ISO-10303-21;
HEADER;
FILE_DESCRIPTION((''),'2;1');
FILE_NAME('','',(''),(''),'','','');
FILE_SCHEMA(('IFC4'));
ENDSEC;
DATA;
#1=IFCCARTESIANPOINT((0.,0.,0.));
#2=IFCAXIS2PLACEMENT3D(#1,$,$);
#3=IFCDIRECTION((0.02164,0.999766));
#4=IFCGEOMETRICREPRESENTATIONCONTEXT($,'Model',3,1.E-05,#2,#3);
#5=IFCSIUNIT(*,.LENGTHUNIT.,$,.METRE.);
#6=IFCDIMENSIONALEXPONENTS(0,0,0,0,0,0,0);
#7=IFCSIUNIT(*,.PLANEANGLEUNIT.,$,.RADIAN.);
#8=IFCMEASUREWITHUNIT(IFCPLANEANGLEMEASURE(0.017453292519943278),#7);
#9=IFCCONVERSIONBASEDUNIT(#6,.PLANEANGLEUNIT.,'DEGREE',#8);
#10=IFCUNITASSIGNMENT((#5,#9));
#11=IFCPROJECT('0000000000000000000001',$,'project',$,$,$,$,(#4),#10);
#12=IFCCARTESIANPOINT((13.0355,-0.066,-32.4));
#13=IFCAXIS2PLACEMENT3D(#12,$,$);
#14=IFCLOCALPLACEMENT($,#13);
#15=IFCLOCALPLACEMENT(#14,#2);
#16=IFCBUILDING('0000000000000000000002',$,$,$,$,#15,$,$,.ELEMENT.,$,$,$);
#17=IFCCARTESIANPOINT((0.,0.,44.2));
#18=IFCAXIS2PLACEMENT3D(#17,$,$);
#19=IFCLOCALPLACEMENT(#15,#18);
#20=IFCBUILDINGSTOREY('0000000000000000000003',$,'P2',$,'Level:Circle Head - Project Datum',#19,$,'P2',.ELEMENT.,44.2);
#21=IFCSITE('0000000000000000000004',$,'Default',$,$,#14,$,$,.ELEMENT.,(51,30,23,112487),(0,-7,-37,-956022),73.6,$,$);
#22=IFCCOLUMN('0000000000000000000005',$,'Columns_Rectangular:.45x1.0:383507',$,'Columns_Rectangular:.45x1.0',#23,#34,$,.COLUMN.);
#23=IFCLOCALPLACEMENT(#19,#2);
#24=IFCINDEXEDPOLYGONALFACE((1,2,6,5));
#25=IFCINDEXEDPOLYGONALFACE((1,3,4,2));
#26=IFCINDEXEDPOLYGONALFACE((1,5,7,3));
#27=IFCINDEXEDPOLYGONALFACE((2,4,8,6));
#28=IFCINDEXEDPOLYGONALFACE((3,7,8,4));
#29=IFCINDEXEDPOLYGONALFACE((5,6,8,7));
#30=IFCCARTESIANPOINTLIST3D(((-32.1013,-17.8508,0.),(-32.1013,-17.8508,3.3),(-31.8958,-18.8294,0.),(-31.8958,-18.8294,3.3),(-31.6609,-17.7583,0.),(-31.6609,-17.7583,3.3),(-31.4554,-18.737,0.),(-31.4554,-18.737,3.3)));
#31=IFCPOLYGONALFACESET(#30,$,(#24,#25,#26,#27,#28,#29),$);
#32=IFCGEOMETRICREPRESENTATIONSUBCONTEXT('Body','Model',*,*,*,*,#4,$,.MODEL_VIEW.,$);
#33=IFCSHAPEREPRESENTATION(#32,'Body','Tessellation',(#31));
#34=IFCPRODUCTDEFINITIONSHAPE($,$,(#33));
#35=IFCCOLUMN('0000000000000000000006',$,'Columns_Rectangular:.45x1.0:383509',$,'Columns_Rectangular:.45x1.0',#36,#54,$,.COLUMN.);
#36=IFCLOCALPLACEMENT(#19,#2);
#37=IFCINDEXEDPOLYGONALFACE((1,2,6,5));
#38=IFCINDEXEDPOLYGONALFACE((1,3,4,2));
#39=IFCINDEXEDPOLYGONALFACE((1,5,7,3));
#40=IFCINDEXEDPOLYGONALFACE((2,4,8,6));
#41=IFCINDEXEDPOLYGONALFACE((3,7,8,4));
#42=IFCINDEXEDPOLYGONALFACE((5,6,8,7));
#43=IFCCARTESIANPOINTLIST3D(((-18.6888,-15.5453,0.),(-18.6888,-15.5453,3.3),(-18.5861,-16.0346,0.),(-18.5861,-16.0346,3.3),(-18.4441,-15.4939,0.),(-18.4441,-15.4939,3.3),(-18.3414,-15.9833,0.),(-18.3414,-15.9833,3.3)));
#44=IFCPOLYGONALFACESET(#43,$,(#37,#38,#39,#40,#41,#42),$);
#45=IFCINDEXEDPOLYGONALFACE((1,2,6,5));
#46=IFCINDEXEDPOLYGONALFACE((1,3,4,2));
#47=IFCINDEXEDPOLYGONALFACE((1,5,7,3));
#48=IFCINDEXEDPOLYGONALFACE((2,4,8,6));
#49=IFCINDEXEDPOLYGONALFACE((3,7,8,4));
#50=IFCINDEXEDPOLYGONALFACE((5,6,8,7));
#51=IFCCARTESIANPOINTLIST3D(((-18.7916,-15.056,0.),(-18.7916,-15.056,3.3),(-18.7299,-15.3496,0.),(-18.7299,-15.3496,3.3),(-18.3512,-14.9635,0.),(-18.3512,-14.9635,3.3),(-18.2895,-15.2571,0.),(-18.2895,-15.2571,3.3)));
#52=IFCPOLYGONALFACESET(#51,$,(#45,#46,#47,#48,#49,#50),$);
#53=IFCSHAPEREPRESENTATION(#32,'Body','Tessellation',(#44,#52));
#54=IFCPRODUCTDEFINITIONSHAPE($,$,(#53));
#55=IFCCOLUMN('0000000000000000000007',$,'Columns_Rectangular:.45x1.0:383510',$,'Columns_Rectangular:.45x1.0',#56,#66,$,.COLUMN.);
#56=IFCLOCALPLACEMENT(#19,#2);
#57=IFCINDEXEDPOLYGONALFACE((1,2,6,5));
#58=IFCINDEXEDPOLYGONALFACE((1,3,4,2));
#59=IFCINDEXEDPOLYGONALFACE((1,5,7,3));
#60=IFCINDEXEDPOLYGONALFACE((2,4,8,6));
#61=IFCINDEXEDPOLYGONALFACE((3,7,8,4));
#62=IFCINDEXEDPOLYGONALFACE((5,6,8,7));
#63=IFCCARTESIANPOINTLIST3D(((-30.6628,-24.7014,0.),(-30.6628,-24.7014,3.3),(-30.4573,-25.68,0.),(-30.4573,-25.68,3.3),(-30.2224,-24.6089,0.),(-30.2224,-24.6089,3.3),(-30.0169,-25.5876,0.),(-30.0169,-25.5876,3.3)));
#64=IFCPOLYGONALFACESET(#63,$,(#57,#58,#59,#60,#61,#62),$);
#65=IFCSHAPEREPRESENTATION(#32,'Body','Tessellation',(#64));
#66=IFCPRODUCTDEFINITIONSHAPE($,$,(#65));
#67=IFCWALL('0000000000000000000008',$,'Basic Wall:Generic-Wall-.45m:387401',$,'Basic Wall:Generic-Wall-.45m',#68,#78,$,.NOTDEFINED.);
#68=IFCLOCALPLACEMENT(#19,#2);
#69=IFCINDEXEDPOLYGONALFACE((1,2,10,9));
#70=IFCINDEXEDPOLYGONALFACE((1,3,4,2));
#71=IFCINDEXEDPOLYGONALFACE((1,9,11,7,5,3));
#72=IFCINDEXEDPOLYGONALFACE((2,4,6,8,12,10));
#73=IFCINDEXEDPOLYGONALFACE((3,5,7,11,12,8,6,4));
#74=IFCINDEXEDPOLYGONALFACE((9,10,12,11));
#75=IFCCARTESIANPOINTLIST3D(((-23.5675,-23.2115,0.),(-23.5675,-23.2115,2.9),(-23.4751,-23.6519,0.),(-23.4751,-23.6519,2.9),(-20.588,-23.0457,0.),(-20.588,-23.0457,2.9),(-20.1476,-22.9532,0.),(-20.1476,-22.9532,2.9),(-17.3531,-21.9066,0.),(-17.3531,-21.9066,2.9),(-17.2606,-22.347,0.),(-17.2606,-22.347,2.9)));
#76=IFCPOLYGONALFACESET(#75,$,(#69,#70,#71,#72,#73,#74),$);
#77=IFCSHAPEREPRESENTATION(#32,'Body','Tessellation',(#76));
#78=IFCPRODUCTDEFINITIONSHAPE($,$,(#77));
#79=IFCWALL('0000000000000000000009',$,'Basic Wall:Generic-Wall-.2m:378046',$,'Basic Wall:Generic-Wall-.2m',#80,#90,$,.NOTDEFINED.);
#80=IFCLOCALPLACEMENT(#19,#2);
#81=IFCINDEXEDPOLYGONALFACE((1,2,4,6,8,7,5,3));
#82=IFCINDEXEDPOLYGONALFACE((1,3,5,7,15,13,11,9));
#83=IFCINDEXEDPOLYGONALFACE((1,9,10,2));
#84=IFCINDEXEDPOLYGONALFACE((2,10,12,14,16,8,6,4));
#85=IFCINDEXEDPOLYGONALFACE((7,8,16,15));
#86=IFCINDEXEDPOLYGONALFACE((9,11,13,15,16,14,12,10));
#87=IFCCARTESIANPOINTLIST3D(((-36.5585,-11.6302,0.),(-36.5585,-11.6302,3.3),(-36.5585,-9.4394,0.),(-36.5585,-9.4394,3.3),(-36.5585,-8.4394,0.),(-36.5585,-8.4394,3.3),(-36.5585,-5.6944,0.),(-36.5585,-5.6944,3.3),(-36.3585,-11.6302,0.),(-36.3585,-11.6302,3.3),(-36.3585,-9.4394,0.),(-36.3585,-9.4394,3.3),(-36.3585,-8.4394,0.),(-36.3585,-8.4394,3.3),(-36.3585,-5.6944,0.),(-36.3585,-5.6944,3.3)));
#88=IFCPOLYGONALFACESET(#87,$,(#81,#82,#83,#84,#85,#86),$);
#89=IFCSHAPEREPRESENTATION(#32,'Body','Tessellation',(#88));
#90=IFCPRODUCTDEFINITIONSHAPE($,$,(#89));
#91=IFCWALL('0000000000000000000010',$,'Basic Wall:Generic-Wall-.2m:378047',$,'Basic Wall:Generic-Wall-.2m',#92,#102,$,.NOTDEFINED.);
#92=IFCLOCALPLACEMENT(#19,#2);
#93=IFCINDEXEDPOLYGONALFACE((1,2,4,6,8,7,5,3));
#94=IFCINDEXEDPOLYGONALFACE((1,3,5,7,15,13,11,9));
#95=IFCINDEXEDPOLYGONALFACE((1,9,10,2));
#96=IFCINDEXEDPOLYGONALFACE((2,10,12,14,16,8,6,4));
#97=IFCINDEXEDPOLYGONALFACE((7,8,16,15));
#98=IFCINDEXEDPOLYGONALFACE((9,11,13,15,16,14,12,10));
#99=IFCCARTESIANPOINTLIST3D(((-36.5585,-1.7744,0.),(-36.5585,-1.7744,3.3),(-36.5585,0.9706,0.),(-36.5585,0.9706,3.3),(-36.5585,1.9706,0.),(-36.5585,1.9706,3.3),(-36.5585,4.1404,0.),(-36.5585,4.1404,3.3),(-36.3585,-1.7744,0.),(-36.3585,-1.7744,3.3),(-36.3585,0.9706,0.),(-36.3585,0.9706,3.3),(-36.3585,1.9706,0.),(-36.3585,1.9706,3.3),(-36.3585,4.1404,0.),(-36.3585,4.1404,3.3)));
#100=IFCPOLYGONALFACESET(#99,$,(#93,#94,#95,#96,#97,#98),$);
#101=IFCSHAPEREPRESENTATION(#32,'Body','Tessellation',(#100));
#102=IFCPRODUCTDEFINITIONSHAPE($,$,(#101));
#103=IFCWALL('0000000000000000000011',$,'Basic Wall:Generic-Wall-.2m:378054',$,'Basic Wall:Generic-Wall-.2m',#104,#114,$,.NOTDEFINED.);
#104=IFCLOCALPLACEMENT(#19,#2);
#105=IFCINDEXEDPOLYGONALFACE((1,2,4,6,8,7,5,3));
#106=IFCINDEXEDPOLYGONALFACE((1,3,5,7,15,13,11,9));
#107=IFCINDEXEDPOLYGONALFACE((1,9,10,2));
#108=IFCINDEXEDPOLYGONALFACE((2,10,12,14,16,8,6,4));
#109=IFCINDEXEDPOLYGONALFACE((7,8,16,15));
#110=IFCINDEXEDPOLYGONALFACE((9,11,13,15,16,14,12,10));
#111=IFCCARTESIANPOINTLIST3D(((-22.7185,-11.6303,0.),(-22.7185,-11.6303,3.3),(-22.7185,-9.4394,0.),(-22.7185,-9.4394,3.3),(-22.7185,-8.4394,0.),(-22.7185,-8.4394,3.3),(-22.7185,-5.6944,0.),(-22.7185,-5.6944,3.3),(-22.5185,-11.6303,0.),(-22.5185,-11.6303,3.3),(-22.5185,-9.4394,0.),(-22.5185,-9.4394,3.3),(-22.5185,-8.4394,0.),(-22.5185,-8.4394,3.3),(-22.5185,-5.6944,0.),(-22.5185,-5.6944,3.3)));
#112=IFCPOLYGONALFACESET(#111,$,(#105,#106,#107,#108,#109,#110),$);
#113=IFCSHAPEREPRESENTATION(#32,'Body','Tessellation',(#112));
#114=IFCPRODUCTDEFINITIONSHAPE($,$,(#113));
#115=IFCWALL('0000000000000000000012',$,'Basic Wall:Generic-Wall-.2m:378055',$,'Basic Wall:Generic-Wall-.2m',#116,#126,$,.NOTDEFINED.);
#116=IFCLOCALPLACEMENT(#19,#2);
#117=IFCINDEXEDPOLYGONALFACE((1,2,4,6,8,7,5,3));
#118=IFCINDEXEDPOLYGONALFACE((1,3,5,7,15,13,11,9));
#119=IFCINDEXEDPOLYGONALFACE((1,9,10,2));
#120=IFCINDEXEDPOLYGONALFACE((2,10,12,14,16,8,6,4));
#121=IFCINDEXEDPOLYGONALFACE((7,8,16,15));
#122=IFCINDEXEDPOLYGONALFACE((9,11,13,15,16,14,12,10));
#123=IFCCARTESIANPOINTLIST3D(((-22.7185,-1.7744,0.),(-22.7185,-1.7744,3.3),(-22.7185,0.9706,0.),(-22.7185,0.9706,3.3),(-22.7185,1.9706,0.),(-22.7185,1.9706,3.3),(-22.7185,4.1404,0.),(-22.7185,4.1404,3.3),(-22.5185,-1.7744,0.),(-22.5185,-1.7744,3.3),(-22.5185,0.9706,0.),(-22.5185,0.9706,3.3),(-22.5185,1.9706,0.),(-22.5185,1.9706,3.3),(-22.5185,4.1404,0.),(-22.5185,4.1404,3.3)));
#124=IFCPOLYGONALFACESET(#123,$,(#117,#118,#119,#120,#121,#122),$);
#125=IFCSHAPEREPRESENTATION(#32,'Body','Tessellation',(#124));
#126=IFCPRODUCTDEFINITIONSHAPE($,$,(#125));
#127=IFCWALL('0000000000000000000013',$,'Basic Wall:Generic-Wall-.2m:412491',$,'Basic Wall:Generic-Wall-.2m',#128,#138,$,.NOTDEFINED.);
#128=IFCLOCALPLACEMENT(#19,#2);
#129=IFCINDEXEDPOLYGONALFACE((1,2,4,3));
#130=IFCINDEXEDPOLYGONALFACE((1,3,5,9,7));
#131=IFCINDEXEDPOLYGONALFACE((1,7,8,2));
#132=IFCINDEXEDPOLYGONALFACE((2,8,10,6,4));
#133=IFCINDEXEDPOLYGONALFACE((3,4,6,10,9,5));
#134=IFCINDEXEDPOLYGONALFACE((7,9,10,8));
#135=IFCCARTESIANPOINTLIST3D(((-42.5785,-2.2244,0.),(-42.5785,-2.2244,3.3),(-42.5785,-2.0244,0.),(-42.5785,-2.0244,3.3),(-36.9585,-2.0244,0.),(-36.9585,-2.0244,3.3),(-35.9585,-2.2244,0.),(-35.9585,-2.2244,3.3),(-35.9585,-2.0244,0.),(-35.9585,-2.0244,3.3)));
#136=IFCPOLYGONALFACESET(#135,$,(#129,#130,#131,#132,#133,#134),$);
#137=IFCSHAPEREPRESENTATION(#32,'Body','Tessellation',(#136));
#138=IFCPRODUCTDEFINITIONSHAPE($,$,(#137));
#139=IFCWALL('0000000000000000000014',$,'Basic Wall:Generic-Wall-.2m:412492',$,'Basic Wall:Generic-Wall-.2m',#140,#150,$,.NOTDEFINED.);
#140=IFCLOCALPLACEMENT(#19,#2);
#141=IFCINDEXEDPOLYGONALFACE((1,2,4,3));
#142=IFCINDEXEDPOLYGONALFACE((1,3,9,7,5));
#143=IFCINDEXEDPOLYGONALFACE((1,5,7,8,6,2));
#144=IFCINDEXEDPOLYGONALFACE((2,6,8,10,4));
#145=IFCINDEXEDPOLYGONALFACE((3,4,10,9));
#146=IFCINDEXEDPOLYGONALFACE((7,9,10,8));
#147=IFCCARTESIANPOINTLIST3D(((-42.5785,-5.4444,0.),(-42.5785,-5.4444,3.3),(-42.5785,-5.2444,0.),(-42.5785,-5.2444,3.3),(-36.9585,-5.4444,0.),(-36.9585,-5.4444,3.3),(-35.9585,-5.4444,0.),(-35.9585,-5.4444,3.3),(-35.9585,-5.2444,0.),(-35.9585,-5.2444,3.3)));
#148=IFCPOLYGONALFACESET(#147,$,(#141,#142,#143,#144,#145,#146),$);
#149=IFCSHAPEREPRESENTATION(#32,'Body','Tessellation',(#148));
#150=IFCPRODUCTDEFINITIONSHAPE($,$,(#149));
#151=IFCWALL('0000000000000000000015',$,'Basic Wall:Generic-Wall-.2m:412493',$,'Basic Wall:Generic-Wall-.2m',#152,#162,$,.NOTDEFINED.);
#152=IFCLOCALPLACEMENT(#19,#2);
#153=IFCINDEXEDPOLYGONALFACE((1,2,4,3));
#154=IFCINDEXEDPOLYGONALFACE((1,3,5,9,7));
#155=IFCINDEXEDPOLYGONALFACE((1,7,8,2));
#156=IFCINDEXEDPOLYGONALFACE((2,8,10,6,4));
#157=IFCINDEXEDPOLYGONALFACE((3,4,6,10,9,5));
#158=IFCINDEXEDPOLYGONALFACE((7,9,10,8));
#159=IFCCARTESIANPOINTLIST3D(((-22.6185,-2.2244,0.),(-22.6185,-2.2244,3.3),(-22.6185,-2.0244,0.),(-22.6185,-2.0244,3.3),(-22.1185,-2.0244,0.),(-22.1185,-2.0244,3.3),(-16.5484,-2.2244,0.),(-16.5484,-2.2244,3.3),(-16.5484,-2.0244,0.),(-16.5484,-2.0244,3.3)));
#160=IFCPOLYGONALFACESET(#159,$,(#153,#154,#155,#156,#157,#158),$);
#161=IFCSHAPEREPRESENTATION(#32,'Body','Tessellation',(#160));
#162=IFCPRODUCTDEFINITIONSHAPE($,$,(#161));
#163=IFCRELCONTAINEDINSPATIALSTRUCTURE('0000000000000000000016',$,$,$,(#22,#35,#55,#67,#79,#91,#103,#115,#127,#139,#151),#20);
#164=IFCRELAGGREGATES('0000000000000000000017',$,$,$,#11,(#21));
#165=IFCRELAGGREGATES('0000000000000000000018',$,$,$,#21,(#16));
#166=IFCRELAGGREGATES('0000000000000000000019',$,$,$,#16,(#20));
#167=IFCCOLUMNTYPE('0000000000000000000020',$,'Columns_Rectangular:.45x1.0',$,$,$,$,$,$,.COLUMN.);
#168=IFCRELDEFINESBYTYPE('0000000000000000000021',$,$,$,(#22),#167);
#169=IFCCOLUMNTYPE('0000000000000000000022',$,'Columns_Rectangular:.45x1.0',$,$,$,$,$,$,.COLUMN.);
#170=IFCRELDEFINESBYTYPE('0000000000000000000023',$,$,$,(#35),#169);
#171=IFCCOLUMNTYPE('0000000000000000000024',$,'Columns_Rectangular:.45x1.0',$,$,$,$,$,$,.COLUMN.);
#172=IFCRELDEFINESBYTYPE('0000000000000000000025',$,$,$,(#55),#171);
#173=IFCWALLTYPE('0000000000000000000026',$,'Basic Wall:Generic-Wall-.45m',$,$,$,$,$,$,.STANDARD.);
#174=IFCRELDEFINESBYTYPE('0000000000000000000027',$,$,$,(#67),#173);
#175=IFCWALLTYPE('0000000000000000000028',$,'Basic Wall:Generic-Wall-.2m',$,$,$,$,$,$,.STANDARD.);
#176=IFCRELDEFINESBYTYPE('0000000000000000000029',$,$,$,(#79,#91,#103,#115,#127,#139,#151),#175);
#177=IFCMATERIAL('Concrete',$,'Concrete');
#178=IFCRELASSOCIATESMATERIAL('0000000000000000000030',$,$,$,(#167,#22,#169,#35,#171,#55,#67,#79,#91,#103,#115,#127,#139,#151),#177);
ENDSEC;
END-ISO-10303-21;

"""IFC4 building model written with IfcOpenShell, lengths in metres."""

from ifc_helpers import new_model, entity, si_unit, converted_unit, direction, frame, origin, place, context, subcontext, project, spatial, indexed_curve, outline, extrude, source, transform, mapped, material, type_object, type_shapes, element, save


model = new_model("IFC4")

# Units and contexts
model_context = context("Model", 3, precision=1e-05, world=origin(), true_north=direction((0.02164, 0.999766)))
body_context = subcontext(model_context, "Body", "Model", "MODEL_VIEW")
ifc_project = project(units=[si_unit("LENGTHUNIT", "METRE"), converted_unit("PLANEANGLEUNIT", "DEGREE", entity("IfcPlaneAngleMeasure", 0.017453292519943278), si_unit("PLANEANGLEUNIT", "RADIAN"), dimensions=[0, 0, 0, 0, 0, 0, 0])], contexts=[model_context])

# Site, building, storey
site_placement = place(None, frame((13.0355, -0.066, -32.4)))
site = spatial("IfcSite", under=ifc_project, at=site_placement, Name="Default", CompositionType="ELEMENT", RefLatitude=(51, 30, 23, 112487), RefLongitude=(0, -7, -37, -956022), RefElevation=73.6)
building_placement = place(site_placement, origin())
building = spatial("IfcBuilding", under=site, at=building_placement, CompositionType="ELEMENT")
storey_placement = place(building_placement, frame((0.0, 0.0, 44.2)))
storey = spatial("IfcBuildingStorey", under=building, at=storey_placement, Name="P2", ObjectType="Level:Circle Head - Project Datum", LongName="P2", CompositionType="ELEMENT", Elevation=44.2)

# Columns
ifc_material = material(Name="Concrete", Category="Concrete")
column_type_1 = type_object("IfcColumnType", Name="Columns_Rectangular:.45x1.0", PredefinedType="COLUMN", material=ifc_material)
shared_shape_1 = source(origin(), body_context, "Body", "SweptSolid", [
    extrude(outline(indexed_curve([(-0.5, -0.225), (0.5, -0.225), (0.5, 0.225), (-0.5, 0.225), (-0.5, -0.225)], self_intersect=False)), frame((-31.7784, -18.2939, 44.2), z_axis=(0.0, 0.0, 1.0), x_axis=(-0.2055, 0.978657, 0.0)), (0.0, 0.0, 1.0), 3.3),
])
type_shapes(column_type_1, [shared_shape_1])
column_1_placement = place(storey_placement, frame((0.0, 0.0, -44.2)))
element("IfcColumn", 1, at=column_1_placement, inside=storey, type_object=column_type_1, material=ifc_material, Name="Columns_Rectangular:.45x1.0:383507", ObjectType="Columns_Rectangular:.45x1.0", PredefinedType="COLUMN", context=body_context, shape_type="MappedRepresentation", body=[
    mapped(shared_shape_1, transform((0.0, 0.0, 0.0), scale=1.0)),
])
column_type_2 = type_object("IfcColumnType", Name="Columns_Rectangular:.45x1.0", PredefinedType="COLUMN", material=ifc_material)
shared_shape_2 = source(origin(), body_context, "Body", "SweptSolid", [
    extrude(outline(indexed_curve([(-0.125, -0.25), (0.125, -0.25), (0.125, 0.25), (-0.125, 0.25), (-0.125, -0.25)], self_intersect=False)), frame((-18.5151, -15.7643, 44.2), z_axis=(0.0, 0.0, 1.0), x_axis=(0.978657, 0.2055, 0.0)), (0.0, 0.0, 1.0), 3.3),
    extrude(outline(indexed_curve([(-0.15, -0.225), (0.15, -0.225), (0.15, 0.225), (-0.15, 0.225), (-0.15, -0.225)], self_intersect=False)), frame((-18.5405, -15.1565, 44.2), z_axis=(0.0, 0.0, 1.0), x_axis=(0.2055, -0.978657, 0.0)), (0.0, 0.0, 1.0), 3.3),
])
type_shapes(column_type_2, [shared_shape_2])
column_2_placement = place(storey_placement, frame((0.0, 0.0, -44.2)))
element("IfcColumn", 2, at=column_2_placement, inside=storey, type_object=column_type_2, material=ifc_material, Name="Columns_Rectangular:.45x1.0:383509", ObjectType="Columns_Rectangular:.45x1.0", PredefinedType="COLUMN", context=body_context, shape_type="MappedRepresentation", body=[
    mapped(shared_shape_2, transform((0.0, 0.0, 0.0), scale=1.0)),
])
column_type_3 = type_object("IfcColumnType", Name="Columns_Rectangular:.45x1.0", PredefinedType="COLUMN", material=ifc_material)
shared_shape_3 = source(origin(), body_context, "Body", "SweptSolid", [
    extrude(outline(indexed_curve([(-0.5, -0.225), (0.5, -0.225), (0.5, 0.225), (-0.5, 0.225), (-0.5, -0.225)], self_intersect=False)), frame((-30.3399, -25.1445, 44.2), z_axis=(0.0, 0.0, 1.0), x_axis=(-0.2055, 0.978657, 0.0)), (0.0, 0.0, 1.0), 3.3),
])
type_shapes(column_type_3, [shared_shape_3])
column_3_placement = place(storey_placement, frame((0.0, 0.0, -44.2)))
element("IfcColumn", 3, at=column_3_placement, inside=storey, type_object=column_type_3, material=ifc_material, Name="Columns_Rectangular:.45x1.0:383510", ObjectType="Columns_Rectangular:.45x1.0", PredefinedType="COLUMN", context=body_context, shape_type="MappedRepresentation", body=[
    mapped(shared_shape_3, transform((0.0, 0.0, 0.0), scale=1.0)),
])

# Walls
wall_type_1 = type_object("IfcWallType", Name="Basic Wall:Generic-Wall-.45m", PredefinedType="STANDARD")
wall_1_placement = place(storey_placement, frame((-23.5213, -23.4317, 0.0), z_axis=(0.0, 0.0, 1.0), x_axis=(0.978657, 0.2055, 0.0)))
element("IfcWall", 4, at=wall_1_placement, inside=storey, type_object=wall_type_1, material=ifc_material, Name="Basic Wall:Generic-Wall-.45m:387401", ObjectType="Basic Wall:Generic-Wall-.45m", PredefinedType="NOTDEFINED", context=body_context, shape_type="SweptSolid", body=[
    extrude(outline(indexed_curve([(6.35, -0.225), (6.35, 0.225), (0.0, 0.225), (0.0, -0.225), (2.95, -0.225), (3.4, -0.225), (6.35, -0.225)], self_intersect=False)), origin(), (0.0, 0.0, 1.0), 2.9),
])
wall_type_2 = type_object("IfcWallType", Name="Basic Wall:Generic-Wall-.2m", PredefinedType="STANDARD")
wall_2_placement = place(storey_placement, frame((-36.4585, -5.6944, 0.0), z_axis=(0.0, 0.0, 1.0), x_axis=(0.0, -1.0, 0.0)))
element("IfcWall", 5, at=wall_2_placement, inside=storey, type_object=wall_type_2, material=ifc_material, Name="Basic Wall:Generic-Wall-.2m:378046", ObjectType="Basic Wall:Generic-Wall-.2m", PredefinedType="NOTDEFINED", context=body_context, shape_type="SweptSolid", body=[
    extrude(outline(indexed_curve([(5.9357, -0.1), (5.9357, 0.1), (3.745, 0.1), (2.745, 0.1), (0.0, 0.1), (0.0, -0.1), (2.745, -0.1), (3.745, -0.1), (5.9357, -0.1)], self_intersect=False)), origin(), (0.0, 0.0, 1.0), 3.3),
])
wall_3_placement = place(storey_placement, frame((-36.4585, -1.7744, 0.0), z_axis=(0.0, 0.0, 1.0), x_axis=(0.0, 1.0, 0.0)))
element("IfcWall", 6, at=wall_3_placement, inside=storey, type_object=wall_type_2, material=ifc_material, Name="Basic Wall:Generic-Wall-.2m:378047", ObjectType="Basic Wall:Generic-Wall-.2m", PredefinedType="NOTDEFINED", context=body_context, shape_type="SweptSolid", body=[
    extrude(outline(indexed_curve([(5.9149, -0.1), (5.9149, 0.1), (3.745, 0.1), (2.745, 0.1), (0.0, 0.1), (0.0, -0.1), (2.745, -0.1), (3.745, -0.1), (5.9149, -0.1)], self_intersect=False)), origin(), (0.0, 0.0, 1.0), 3.3),
])
wall_4_placement = place(storey_placement, frame((-22.6185, -5.6944, 0.0), z_axis=(0.0, 0.0, 1.0), x_axis=(0.0, -1.0, 0.0)))
element("IfcWall", 7, at=wall_4_placement, inside=storey, type_object=wall_type_2, material=ifc_material, Name="Basic Wall:Generic-Wall-.2m:378054", ObjectType="Basic Wall:Generic-Wall-.2m", PredefinedType="NOTDEFINED", context=body_context, shape_type="SweptSolid", body=[
    extrude(outline(indexed_curve([(5.9358, -0.1), (5.9359, 0.1), (3.745, 0.1), (2.745, 0.1), (0.0, 0.1), (0.0, -0.1), (2.745, -0.1), (3.745, -0.1), (5.9358, -0.1)], self_intersect=False)), origin(), (0.0, 0.0, 1.0), 3.3),
])
wall_5_placement = place(storey_placement, frame((-22.6185, -1.7744, 0.0), z_axis=(0.0, 0.0, 1.0), x_axis=(0.0, 1.0, 0.0)))
element("IfcWall", 8, at=wall_5_placement, inside=storey, type_object=wall_type_2, material=ifc_material, Name="Basic Wall:Generic-Wall-.2m:378055", ObjectType="Basic Wall:Generic-Wall-.2m", PredefinedType="NOTDEFINED", context=body_context, shape_type="SweptSolid", body=[
    extrude(outline(indexed_curve([(5.9149, -0.1), (5.9149, 0.1), (3.745, 0.1), (2.745, 0.1), (0.0, 0.1), (0.0, -0.1), (2.745, -0.1), (3.745, -0.1), (5.9149, -0.1)], self_intersect=False)), origin(), (0.0, 0.0, 1.0), 3.3),
])
wall_6_placement = place(storey_placement, frame((-35.9585, -2.1244, 0.0), z_axis=(0.0, 0.0, 1.0), x_axis=(-1.0, 0.0, 0.0)))
element("IfcWall", 9, at=wall_6_placement, inside=storey, type_object=wall_type_2, material=ifc_material, Name="Basic Wall:Generic-Wall-.2m:412491", ObjectType="Basic Wall:Generic-Wall-.2m", PredefinedType="NOTDEFINED", context=body_context, shape_type="SweptSolid", body=[
    extrude(outline(indexed_curve([(6.6201, -0.1), (6.6201, 0.1), (0.0, 0.1), (0.0, -0.1), (1.0, -0.1), (6.6201, -0.1)], self_intersect=False)), origin(), (0.0, 0.0, 1.0), 3.3),
])
wall_7_placement = place(storey_placement, frame((-35.9585, -5.3444, 0.0), z_axis=(0.0, 0.0, 1.0), x_axis=(-1.0, 0.0, 0.0)))
element("IfcWall", 10, at=wall_7_placement, inside=storey, type_object=wall_type_2, material=ifc_material, Name="Basic Wall:Generic-Wall-.2m:412492", ObjectType="Basic Wall:Generic-Wall-.2m", PredefinedType="NOTDEFINED", context=body_context, shape_type="SweptSolid", body=[
    extrude(outline(indexed_curve([(6.62, -0.1), (6.62, 0.1), (1.0, 0.1), (0.0, 0.1), (0.0, -0.1), (6.62, -0.1)], self_intersect=False)), origin(), (0.0, 0.0, 1.0), 3.3),
])
wall_8_placement = place(storey_placement, frame((-22.6185, -2.1244, 0.0)))
element("IfcWall", 11, at=wall_8_placement, inside=storey, type_object=wall_type_2, material=ifc_material, Name="Basic Wall:Generic-Wall-.2m:412493", ObjectType="Basic Wall:Generic-Wall-.2m", PredefinedType="NOTDEFINED", context=body_context, shape_type="SweptSolid", body=[
    extrude(outline(indexed_curve([(6.0701, -0.1), (6.0701, 0.1), (0.5, 0.1), (0.0, 0.1), (0.0, -0.1), (6.0701, -0.1)], self_intersect=False)), origin(), (0.0, 0.0, 1.0), 3.3),
])

save(model, "model.ifc")
